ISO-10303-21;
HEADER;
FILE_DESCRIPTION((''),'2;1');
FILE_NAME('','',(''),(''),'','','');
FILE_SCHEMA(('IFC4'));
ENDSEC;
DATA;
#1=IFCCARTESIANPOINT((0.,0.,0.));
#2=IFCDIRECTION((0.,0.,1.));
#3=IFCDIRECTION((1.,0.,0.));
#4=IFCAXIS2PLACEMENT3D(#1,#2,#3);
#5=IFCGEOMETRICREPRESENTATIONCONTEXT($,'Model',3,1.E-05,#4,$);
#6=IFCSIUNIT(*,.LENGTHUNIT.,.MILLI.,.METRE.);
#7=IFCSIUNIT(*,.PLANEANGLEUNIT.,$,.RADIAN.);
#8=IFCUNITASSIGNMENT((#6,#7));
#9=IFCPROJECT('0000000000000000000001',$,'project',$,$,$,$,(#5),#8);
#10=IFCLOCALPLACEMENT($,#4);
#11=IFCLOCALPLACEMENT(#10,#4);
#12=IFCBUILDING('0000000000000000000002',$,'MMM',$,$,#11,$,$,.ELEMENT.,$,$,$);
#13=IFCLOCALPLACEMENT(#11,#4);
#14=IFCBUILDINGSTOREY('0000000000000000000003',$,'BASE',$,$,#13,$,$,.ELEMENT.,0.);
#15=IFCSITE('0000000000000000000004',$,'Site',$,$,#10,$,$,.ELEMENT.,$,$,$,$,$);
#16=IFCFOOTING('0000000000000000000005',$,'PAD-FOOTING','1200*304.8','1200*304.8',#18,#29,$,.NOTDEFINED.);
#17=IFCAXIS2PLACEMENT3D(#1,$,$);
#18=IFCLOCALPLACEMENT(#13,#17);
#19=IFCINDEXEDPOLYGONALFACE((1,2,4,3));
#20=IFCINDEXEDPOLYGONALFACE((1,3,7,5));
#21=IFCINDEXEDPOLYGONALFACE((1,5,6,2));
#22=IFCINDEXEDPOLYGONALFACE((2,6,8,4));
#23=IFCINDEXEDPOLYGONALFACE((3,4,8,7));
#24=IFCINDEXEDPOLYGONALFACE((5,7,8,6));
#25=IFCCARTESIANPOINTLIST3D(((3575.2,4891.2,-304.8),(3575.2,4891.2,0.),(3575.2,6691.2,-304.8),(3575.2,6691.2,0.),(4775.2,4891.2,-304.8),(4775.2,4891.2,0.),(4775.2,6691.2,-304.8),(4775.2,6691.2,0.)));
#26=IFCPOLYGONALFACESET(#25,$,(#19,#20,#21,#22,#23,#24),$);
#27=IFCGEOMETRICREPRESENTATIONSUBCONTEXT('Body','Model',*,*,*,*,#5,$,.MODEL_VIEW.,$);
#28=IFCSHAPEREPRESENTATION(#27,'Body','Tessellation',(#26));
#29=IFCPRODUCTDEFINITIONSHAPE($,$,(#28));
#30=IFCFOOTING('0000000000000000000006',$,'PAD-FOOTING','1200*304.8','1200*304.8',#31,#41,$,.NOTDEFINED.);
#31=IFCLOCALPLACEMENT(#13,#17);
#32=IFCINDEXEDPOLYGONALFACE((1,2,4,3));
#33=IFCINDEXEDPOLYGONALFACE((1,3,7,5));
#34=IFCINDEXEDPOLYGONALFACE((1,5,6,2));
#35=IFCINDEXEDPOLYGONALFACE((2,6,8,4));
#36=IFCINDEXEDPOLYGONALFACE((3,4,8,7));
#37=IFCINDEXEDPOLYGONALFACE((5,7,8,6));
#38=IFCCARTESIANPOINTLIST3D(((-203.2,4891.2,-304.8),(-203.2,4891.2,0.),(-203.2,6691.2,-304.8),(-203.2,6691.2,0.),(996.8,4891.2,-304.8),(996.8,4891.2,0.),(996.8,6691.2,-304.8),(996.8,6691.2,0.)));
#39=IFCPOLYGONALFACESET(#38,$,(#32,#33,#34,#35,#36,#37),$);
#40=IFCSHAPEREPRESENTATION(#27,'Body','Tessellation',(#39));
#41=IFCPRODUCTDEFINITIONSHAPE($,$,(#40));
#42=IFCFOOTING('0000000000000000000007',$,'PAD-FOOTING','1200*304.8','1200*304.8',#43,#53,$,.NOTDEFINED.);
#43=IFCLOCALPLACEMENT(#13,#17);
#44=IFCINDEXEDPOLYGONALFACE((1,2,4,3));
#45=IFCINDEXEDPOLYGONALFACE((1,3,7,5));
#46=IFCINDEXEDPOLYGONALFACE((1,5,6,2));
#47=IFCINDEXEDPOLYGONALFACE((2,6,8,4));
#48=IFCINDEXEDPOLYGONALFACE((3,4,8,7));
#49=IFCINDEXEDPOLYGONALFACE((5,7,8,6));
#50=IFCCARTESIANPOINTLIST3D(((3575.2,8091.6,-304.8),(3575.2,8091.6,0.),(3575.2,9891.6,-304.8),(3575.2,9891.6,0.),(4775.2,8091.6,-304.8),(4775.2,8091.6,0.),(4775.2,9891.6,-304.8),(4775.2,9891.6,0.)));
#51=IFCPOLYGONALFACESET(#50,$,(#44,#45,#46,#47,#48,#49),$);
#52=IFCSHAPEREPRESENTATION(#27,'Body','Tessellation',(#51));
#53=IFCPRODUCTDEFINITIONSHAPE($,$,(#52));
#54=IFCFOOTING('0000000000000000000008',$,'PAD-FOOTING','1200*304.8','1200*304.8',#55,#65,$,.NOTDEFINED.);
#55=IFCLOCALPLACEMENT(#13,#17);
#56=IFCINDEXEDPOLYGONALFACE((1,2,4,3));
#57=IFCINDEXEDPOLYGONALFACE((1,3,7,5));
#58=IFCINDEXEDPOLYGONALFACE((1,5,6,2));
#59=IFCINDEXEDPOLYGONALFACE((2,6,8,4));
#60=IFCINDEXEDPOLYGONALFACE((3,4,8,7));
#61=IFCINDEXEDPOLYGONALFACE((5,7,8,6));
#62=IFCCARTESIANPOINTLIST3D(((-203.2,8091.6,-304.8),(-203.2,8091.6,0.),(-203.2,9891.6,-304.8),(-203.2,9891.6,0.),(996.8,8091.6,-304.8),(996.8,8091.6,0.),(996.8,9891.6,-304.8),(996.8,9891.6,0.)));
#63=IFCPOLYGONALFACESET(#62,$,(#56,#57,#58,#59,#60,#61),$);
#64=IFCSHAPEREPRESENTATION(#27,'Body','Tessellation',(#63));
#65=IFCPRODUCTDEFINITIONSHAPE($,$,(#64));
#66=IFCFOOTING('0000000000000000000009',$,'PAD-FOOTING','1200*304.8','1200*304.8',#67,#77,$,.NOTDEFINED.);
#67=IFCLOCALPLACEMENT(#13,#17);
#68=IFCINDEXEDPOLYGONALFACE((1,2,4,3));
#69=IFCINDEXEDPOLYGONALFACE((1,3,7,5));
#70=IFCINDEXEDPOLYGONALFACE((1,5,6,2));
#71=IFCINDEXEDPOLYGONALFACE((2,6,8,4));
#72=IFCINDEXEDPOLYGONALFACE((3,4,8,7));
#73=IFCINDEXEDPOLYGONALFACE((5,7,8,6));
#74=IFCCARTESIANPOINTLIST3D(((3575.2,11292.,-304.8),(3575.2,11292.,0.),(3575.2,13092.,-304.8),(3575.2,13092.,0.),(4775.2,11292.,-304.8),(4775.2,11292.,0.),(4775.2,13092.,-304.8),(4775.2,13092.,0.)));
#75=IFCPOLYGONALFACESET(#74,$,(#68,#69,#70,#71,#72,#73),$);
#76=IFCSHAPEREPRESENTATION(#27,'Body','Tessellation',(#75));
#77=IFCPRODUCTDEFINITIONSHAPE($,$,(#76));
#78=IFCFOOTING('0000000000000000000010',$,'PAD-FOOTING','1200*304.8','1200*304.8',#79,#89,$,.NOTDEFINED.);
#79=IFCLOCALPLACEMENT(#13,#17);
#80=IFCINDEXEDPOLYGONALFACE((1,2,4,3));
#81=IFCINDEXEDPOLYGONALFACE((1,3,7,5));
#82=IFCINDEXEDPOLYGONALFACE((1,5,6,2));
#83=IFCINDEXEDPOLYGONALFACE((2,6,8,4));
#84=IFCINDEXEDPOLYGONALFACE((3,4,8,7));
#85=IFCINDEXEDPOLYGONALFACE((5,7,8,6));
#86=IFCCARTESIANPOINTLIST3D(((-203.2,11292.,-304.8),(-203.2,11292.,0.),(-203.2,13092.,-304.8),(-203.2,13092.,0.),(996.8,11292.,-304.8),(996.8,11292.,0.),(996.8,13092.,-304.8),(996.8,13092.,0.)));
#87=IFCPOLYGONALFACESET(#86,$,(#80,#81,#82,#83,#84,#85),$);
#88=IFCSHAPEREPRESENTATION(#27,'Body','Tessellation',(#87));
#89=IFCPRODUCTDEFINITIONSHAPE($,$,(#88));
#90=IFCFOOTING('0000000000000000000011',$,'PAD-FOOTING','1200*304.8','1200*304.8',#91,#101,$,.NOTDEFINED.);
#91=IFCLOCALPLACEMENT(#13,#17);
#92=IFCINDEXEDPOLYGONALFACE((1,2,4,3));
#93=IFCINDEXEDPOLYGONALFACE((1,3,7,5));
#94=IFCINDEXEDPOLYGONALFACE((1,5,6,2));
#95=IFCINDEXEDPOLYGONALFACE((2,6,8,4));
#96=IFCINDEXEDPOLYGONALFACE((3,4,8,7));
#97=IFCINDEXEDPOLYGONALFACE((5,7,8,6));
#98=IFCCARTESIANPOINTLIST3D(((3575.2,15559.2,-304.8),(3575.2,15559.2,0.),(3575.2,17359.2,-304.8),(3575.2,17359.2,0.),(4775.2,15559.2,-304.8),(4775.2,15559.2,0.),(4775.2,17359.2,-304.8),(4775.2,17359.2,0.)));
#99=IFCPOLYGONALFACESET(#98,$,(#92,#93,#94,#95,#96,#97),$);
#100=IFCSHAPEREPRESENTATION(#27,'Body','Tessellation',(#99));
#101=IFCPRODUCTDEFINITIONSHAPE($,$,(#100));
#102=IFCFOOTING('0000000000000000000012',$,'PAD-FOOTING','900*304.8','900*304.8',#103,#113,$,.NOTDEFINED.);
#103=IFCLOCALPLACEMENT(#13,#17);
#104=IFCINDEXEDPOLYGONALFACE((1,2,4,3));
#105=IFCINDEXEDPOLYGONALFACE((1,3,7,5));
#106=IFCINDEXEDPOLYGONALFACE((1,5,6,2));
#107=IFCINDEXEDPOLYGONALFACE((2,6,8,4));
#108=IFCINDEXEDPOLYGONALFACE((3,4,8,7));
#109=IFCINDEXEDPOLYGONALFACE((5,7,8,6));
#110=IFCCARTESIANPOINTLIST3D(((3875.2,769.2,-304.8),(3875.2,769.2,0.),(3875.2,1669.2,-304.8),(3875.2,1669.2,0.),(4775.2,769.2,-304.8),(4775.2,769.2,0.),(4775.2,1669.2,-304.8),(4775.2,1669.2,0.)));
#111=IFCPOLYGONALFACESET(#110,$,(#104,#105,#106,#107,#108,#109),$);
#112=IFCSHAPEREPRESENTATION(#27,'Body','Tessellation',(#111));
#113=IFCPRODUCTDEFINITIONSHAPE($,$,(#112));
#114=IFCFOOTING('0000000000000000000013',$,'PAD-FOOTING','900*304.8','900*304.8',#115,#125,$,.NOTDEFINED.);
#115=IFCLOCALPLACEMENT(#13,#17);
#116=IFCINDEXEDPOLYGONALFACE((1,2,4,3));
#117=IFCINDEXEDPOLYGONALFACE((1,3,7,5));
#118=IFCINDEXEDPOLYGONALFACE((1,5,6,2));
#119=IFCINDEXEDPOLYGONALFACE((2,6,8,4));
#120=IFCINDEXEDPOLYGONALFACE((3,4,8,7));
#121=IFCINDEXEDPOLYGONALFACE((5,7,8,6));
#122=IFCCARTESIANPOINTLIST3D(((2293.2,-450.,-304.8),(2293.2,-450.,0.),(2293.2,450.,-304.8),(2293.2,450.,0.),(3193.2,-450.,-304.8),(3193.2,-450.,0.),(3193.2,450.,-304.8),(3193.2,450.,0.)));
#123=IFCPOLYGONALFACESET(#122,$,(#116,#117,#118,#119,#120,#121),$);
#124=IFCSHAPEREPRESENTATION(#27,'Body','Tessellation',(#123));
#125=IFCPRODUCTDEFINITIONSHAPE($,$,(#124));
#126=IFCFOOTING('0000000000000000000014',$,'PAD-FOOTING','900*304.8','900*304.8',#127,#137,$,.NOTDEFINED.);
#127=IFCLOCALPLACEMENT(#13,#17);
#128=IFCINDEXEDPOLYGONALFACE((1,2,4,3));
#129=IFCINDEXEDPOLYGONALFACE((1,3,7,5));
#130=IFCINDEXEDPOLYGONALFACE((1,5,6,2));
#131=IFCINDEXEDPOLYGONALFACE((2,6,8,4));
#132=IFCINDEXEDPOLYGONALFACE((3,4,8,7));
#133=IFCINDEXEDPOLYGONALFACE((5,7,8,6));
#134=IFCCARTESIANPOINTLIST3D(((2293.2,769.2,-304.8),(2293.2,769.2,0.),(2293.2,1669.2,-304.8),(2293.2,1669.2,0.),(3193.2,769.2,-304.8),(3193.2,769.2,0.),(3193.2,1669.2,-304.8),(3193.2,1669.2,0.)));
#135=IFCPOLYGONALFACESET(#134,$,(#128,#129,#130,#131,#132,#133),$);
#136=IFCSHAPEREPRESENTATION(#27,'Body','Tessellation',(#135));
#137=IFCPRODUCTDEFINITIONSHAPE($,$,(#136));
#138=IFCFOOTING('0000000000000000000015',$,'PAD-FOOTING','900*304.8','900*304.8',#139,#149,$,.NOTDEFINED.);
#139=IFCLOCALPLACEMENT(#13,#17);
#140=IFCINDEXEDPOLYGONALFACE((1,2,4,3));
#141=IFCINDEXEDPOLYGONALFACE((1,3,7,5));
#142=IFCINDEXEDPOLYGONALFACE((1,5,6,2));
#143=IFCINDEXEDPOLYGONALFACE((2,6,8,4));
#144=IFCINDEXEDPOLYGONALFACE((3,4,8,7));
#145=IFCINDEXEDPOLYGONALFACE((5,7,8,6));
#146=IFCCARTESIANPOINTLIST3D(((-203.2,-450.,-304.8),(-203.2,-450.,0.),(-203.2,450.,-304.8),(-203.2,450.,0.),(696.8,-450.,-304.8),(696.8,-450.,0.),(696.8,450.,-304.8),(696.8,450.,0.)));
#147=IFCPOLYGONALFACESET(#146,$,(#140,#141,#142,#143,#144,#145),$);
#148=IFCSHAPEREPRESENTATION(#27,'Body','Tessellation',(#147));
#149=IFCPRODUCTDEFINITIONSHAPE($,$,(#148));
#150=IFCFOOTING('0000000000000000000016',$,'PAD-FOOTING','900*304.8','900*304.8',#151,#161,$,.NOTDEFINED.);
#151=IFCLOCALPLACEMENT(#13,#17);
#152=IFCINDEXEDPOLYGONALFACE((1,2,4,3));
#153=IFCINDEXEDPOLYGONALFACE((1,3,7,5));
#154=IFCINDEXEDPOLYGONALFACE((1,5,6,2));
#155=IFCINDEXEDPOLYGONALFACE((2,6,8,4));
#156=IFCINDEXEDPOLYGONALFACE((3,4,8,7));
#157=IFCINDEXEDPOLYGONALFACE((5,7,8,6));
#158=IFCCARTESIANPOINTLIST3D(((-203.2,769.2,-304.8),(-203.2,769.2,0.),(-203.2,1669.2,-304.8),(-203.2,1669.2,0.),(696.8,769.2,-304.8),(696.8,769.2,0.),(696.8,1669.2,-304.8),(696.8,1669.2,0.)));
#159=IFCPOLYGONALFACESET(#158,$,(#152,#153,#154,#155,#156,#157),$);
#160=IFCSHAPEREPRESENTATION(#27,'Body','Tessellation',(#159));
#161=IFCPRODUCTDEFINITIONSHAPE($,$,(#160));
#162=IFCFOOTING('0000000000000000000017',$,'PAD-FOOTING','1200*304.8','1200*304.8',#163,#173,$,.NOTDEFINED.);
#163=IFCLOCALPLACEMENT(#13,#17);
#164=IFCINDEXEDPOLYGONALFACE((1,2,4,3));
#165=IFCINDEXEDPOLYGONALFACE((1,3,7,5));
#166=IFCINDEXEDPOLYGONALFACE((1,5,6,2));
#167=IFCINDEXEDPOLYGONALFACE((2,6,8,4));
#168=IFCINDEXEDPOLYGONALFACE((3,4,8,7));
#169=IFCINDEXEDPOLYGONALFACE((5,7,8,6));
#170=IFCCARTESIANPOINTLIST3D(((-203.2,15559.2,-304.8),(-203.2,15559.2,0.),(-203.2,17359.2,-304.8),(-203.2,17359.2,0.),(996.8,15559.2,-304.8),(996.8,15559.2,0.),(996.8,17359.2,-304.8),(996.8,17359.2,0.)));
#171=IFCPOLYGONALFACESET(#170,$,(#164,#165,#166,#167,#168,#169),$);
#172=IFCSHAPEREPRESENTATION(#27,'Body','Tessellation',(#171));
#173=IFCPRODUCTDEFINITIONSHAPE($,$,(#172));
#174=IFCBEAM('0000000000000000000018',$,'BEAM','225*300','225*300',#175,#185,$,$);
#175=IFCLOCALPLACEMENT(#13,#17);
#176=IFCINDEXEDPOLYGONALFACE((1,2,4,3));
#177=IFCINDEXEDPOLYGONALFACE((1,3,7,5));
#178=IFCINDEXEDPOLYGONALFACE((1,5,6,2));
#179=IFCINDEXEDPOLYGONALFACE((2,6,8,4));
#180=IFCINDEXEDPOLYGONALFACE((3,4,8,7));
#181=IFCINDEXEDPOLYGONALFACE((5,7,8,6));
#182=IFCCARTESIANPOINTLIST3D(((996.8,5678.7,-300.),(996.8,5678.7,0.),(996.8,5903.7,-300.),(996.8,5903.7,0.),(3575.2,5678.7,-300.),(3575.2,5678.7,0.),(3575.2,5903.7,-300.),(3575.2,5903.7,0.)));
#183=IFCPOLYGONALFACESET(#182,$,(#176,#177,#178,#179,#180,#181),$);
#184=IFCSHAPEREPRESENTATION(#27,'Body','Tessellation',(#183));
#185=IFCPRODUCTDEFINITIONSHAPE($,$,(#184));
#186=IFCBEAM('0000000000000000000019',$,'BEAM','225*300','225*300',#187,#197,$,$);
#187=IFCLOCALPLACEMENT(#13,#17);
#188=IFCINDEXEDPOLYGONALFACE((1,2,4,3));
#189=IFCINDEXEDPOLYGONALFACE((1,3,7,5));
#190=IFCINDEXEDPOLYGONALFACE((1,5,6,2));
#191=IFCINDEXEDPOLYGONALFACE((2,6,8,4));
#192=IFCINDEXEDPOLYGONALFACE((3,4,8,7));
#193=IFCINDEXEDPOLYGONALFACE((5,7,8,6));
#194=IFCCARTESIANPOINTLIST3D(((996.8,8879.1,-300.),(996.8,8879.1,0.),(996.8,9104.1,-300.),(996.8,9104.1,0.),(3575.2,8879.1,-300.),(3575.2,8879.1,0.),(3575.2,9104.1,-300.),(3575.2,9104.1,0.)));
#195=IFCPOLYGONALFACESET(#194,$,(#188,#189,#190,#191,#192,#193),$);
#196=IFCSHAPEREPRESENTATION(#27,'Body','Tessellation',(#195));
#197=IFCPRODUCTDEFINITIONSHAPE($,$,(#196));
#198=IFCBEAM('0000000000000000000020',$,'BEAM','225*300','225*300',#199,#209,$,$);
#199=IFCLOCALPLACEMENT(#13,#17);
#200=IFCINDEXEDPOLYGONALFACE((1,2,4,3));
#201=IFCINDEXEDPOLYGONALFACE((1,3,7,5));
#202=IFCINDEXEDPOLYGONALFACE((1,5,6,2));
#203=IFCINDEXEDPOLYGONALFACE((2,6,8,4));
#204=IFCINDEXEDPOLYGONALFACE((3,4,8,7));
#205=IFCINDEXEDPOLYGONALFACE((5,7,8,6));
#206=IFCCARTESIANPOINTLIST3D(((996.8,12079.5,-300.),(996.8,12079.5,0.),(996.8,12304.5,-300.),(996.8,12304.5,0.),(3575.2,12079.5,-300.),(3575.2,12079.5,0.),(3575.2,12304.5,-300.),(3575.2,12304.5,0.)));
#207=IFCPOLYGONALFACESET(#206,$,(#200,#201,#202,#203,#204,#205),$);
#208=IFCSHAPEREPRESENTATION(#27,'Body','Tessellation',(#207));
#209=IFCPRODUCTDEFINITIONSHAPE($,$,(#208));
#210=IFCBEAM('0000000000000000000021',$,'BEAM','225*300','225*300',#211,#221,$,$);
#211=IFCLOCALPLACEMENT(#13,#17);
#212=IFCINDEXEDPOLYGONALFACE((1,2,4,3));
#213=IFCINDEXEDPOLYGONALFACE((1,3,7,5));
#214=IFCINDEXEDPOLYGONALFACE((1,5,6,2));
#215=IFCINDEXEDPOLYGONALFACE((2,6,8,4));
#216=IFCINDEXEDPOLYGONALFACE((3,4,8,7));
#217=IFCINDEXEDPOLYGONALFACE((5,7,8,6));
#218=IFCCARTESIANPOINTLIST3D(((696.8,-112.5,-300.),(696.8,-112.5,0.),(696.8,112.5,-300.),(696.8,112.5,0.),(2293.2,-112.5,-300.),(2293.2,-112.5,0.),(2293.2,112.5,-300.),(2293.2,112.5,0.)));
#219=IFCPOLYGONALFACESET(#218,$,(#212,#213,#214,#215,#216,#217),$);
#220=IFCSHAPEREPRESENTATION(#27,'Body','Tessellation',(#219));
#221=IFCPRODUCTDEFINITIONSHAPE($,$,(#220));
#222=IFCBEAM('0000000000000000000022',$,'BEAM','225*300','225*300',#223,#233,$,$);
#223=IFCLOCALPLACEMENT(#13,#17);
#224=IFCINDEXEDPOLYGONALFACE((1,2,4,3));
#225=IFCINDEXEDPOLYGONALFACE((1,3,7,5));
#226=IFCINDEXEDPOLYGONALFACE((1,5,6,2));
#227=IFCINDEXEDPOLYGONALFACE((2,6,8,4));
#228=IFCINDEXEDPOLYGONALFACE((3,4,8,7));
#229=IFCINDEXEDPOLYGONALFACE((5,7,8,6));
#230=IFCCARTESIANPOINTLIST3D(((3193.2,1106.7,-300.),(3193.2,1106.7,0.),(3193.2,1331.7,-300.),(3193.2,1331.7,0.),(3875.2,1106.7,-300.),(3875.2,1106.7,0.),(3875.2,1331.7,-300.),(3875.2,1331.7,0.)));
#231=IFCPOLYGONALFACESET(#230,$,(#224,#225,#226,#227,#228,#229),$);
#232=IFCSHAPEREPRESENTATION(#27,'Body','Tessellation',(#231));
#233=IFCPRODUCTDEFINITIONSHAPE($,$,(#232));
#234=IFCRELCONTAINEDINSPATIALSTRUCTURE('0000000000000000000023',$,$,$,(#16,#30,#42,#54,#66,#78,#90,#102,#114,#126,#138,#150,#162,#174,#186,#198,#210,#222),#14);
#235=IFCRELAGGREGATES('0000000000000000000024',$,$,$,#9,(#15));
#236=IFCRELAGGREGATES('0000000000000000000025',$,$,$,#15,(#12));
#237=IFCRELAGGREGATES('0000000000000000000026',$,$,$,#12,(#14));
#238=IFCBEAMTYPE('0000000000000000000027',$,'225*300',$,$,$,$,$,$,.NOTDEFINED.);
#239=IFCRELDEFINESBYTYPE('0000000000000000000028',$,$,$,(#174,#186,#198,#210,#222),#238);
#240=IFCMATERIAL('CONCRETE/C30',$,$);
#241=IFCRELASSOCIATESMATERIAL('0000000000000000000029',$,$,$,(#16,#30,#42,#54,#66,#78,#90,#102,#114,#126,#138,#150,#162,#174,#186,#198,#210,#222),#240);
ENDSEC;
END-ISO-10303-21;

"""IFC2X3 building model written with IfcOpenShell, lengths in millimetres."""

from ifc_helpers import new_model, si_unit, frame, origin_with_axes, origin_2d_with_axis, place, context, subcontext, project, spatial, rectangle, extrude, material, type_object, element, save


model = new_model("IFC2X3")

# Units and contexts
model_context = context("Model", 3, precision=1e-05, world=origin_with_axes())
body_context = subcontext(model_context, "Body", "Model", "MODEL_VIEW")
ifc_project = project(units=[si_unit("LENGTHUNIT", "METRE", prefix="MILLI"), si_unit("PLANEANGLEUNIT", "RADIAN")], contexts=[model_context])

# Site, building, storey
site_placement = place(None, origin_with_axes())
site = spatial("IfcSite", under=ifc_project, at=site_placement, Name="Site", CompositionType="ELEMENT")
building_placement = place(site_placement, origin_with_axes())
building = spatial("IfcBuilding", under=site, at=building_placement, Name="MMM", CompositionType="ELEMENT")
storey_placement = place(building_placement, origin_with_axes())
storey = spatial("IfcBuildingStorey", under=building, at=storey_placement, Name="BASE", CompositionType="ELEMENT", Elevation=0.0)

# Footings
ifc_material = material(Name="CONCRETE/C30")
for number, where, z_axis, x_axis, name in (
    (1, (4175.2, 5791.2, -304.8), (0.0, 1.0, 0.0), (0.0, 0.0, 1.0), "PAD-FOOTING"),
    (2, (396.8, 5791.2, -304.8), (0.0, 1.0, 0.0), (0.0, 0.0, 1.0), "PAD-FOOTING"),
    (3, (4175.2, 8991.6, -304.8), (0.0, 1.0, 0.0), (0.0, 0.0, 1.0), "PAD-FOOTING"),
    (4, (396.8, 8991.6, -304.8), (0.0, 1.0, 0.0), (0.0, 0.0, 1.0), "PAD-FOOTING"),
    (5, (4175.2, 12192.0, -304.8), (0.0, 1.0, 0.0), (0.0, 0.0, 1.0), "PAD-FOOTING"),
    (6, (396.8, 12192.0, -304.8), (0.0, 1.0, 0.0), (0.0, 0.0, 1.0), "PAD-FOOTING"),
    (7, (4175.2, 16459.2, -304.8), (0.0, 1.0, 0.0), (0.0, 0.0, 1.0), "PAD-FOOTING"),
):
    element("IfcFooting", number, at=place(storey_placement, frame(where, z_axis=z_axis, x_axis=x_axis)), inside=storey, material=ifc_material, Name=name, Description="1200*304.8", ObjectType="1200*304.8", PredefinedType="NOTDEFINED", context=body_context, shape_type="SweptSolid", body=[
        extrude(rectangle(XDim=1200.0, YDim=1800.0, at=origin_2d_with_axis()), frame((304.8, 0.0, 0.0), z_axis=(-1.0, 0.0, 0.0), x_axis=(0.0, -1.0, 0.0)), (0.0, 0.0, 1.0), 304.8),
    ])
for number, where, z_axis, x_axis, name in (
    (8, (4325.2, 1219.2, -304.8), (0.0, 1.0, 0.0), (0.0, 0.0, 1.0), "PAD-FOOTING"),
    (9, (2743.2, 0.0, -304.8), (0.0, 1.0, 0.0), (0.0, 0.0, 1.0), "PAD-FOOTING"),
    (10, (2743.2, 1219.2, -304.8), (0.0, 1.0, 0.0), (0.0, 0.0, 1.0), "PAD-FOOTING"),
    (11, (246.8, 0.0, -304.8), (0.0, 1.0, 0.0), (0.0, 0.0, 1.0), "PAD-FOOTING"),
    (12, (246.8, 1219.2, -304.8), (0.0, 1.0, 0.0), (0.0, 0.0, 1.0), "PAD-FOOTING"),
):
    element("IfcFooting", number, at=place(storey_placement, frame(where, z_axis=z_axis, x_axis=x_axis)), inside=storey, material=ifc_material, Name=name, Description="900*304.8", ObjectType="900*304.8", PredefinedType="NOTDEFINED", context=body_context, shape_type="SweptSolid", body=[
        extrude(rectangle(XDim=900.0, YDim=900.0, at=origin_2d_with_axis()), frame((304.8, 0.0, 0.0), z_axis=(-1.0, 0.0, 0.0), x_axis=(0.0, -1.0, 0.0)), (0.0, 0.0, 1.0), 304.8),
    ])
footing_placement = place(storey_placement, frame((396.8, 16459.2, -304.8), z_axis=(0.0, 1.0, 0.0), x_axis=(0.0, 0.0, 1.0)))
element("IfcFooting", 13, at=footing_placement, inside=storey, material=ifc_material, Name="PAD-FOOTING", Description="1200*304.8", ObjectType="1200*304.8", PredefinedType="NOTDEFINED", context=body_context, shape_type="SweptSolid", body=[
    extrude(rectangle(XDim=1200.0, YDim=1800.0, at=origin_2d_with_axis()), frame((304.8, 0.0, 0.0), z_axis=(-1.0, 0.0, 0.0), x_axis=(0.0, -1.0, 0.0)), (0.0, 0.0, 1.0), 304.8),
])

# Beams
beam_type = type_object("IfcBeamType", Name="225*300", PredefinedType="NOTDEFINED")
for number, where, z_axis, x_axis, name in (
    (14, (996.8, 5791.2, -150.0), (0.0, 0.0, 1.0), (1.0, 0.0, 0.0), "BEAM"),
    (15, (996.8, 8991.6, -150.0), (0.0, 0.0, 1.0), (1.0, 0.0, 0.0), "BEAM"),
    (16, (996.8, 12192.0, -150.0), (0.0, 0.0, 1.0), (1.0, 0.0, 0.0), "BEAM"),
):
    element("IfcBeam", number, at=place(storey_placement, frame(where, z_axis=z_axis, x_axis=x_axis)), inside=storey, type_object=beam_type, material=ifc_material, Name=name, Description="225*300", ObjectType="225*300", context=body_context, shape_type="SweptSolid", body=[
        extrude(rectangle(XDim=225.0, YDim=300.0, at=origin_2d_with_axis()), frame((2578.4, 0.0, 0.0), z_axis=(-1.0, 0.0, 0.0), x_axis=(0.0, -1.0, 0.0)), (0.0, 0.0, 1.0), 2578.4),
    ])
beam_1_placement = place(storey_placement, frame((696.8, 0.0, -150.0), z_axis=(0.0, 0.0, 1.0), x_axis=(1.0, 0.0, 0.0)))
element("IfcBeam", 17, at=beam_1_placement, inside=storey, type_object=beam_type, material=ifc_material, Name="BEAM", Description="225*300", ObjectType="225*300", context=body_context, shape_type="SweptSolid", body=[
    extrude(rectangle(XDim=225.0, YDim=300.0, at=origin_2d_with_axis()), frame((1596.4, 0.0, 0.0), z_axis=(-1.0, 0.0, 0.0), x_axis=(0.0, -1.0, 0.0)), (0.0, 0.0, 1.0), 1596.4),
])
beam_2_placement = place(storey_placement, frame((3193.2, 1219.2, -150.0), z_axis=(0.0, 0.0, 1.0), x_axis=(1.0, 0.0, 0.0)))
element("IfcBeam", 18, at=beam_2_placement, inside=storey, type_object=beam_type, material=ifc_material, Name="BEAM", Description="225*300", ObjectType="225*300", context=body_context, shape_type="SweptSolid", body=[
    extrude(rectangle(XDim=225.0, YDim=300.0, at=origin_2d_with_axis()), frame((682.0, 0.0, 0.0), z_axis=(-1.0, 0.0, 0.0), x_axis=(0.0, -1.0, 0.0)), (0.0, 0.0, 1.0), 682.0),
])

save(model, "model.ifc")
